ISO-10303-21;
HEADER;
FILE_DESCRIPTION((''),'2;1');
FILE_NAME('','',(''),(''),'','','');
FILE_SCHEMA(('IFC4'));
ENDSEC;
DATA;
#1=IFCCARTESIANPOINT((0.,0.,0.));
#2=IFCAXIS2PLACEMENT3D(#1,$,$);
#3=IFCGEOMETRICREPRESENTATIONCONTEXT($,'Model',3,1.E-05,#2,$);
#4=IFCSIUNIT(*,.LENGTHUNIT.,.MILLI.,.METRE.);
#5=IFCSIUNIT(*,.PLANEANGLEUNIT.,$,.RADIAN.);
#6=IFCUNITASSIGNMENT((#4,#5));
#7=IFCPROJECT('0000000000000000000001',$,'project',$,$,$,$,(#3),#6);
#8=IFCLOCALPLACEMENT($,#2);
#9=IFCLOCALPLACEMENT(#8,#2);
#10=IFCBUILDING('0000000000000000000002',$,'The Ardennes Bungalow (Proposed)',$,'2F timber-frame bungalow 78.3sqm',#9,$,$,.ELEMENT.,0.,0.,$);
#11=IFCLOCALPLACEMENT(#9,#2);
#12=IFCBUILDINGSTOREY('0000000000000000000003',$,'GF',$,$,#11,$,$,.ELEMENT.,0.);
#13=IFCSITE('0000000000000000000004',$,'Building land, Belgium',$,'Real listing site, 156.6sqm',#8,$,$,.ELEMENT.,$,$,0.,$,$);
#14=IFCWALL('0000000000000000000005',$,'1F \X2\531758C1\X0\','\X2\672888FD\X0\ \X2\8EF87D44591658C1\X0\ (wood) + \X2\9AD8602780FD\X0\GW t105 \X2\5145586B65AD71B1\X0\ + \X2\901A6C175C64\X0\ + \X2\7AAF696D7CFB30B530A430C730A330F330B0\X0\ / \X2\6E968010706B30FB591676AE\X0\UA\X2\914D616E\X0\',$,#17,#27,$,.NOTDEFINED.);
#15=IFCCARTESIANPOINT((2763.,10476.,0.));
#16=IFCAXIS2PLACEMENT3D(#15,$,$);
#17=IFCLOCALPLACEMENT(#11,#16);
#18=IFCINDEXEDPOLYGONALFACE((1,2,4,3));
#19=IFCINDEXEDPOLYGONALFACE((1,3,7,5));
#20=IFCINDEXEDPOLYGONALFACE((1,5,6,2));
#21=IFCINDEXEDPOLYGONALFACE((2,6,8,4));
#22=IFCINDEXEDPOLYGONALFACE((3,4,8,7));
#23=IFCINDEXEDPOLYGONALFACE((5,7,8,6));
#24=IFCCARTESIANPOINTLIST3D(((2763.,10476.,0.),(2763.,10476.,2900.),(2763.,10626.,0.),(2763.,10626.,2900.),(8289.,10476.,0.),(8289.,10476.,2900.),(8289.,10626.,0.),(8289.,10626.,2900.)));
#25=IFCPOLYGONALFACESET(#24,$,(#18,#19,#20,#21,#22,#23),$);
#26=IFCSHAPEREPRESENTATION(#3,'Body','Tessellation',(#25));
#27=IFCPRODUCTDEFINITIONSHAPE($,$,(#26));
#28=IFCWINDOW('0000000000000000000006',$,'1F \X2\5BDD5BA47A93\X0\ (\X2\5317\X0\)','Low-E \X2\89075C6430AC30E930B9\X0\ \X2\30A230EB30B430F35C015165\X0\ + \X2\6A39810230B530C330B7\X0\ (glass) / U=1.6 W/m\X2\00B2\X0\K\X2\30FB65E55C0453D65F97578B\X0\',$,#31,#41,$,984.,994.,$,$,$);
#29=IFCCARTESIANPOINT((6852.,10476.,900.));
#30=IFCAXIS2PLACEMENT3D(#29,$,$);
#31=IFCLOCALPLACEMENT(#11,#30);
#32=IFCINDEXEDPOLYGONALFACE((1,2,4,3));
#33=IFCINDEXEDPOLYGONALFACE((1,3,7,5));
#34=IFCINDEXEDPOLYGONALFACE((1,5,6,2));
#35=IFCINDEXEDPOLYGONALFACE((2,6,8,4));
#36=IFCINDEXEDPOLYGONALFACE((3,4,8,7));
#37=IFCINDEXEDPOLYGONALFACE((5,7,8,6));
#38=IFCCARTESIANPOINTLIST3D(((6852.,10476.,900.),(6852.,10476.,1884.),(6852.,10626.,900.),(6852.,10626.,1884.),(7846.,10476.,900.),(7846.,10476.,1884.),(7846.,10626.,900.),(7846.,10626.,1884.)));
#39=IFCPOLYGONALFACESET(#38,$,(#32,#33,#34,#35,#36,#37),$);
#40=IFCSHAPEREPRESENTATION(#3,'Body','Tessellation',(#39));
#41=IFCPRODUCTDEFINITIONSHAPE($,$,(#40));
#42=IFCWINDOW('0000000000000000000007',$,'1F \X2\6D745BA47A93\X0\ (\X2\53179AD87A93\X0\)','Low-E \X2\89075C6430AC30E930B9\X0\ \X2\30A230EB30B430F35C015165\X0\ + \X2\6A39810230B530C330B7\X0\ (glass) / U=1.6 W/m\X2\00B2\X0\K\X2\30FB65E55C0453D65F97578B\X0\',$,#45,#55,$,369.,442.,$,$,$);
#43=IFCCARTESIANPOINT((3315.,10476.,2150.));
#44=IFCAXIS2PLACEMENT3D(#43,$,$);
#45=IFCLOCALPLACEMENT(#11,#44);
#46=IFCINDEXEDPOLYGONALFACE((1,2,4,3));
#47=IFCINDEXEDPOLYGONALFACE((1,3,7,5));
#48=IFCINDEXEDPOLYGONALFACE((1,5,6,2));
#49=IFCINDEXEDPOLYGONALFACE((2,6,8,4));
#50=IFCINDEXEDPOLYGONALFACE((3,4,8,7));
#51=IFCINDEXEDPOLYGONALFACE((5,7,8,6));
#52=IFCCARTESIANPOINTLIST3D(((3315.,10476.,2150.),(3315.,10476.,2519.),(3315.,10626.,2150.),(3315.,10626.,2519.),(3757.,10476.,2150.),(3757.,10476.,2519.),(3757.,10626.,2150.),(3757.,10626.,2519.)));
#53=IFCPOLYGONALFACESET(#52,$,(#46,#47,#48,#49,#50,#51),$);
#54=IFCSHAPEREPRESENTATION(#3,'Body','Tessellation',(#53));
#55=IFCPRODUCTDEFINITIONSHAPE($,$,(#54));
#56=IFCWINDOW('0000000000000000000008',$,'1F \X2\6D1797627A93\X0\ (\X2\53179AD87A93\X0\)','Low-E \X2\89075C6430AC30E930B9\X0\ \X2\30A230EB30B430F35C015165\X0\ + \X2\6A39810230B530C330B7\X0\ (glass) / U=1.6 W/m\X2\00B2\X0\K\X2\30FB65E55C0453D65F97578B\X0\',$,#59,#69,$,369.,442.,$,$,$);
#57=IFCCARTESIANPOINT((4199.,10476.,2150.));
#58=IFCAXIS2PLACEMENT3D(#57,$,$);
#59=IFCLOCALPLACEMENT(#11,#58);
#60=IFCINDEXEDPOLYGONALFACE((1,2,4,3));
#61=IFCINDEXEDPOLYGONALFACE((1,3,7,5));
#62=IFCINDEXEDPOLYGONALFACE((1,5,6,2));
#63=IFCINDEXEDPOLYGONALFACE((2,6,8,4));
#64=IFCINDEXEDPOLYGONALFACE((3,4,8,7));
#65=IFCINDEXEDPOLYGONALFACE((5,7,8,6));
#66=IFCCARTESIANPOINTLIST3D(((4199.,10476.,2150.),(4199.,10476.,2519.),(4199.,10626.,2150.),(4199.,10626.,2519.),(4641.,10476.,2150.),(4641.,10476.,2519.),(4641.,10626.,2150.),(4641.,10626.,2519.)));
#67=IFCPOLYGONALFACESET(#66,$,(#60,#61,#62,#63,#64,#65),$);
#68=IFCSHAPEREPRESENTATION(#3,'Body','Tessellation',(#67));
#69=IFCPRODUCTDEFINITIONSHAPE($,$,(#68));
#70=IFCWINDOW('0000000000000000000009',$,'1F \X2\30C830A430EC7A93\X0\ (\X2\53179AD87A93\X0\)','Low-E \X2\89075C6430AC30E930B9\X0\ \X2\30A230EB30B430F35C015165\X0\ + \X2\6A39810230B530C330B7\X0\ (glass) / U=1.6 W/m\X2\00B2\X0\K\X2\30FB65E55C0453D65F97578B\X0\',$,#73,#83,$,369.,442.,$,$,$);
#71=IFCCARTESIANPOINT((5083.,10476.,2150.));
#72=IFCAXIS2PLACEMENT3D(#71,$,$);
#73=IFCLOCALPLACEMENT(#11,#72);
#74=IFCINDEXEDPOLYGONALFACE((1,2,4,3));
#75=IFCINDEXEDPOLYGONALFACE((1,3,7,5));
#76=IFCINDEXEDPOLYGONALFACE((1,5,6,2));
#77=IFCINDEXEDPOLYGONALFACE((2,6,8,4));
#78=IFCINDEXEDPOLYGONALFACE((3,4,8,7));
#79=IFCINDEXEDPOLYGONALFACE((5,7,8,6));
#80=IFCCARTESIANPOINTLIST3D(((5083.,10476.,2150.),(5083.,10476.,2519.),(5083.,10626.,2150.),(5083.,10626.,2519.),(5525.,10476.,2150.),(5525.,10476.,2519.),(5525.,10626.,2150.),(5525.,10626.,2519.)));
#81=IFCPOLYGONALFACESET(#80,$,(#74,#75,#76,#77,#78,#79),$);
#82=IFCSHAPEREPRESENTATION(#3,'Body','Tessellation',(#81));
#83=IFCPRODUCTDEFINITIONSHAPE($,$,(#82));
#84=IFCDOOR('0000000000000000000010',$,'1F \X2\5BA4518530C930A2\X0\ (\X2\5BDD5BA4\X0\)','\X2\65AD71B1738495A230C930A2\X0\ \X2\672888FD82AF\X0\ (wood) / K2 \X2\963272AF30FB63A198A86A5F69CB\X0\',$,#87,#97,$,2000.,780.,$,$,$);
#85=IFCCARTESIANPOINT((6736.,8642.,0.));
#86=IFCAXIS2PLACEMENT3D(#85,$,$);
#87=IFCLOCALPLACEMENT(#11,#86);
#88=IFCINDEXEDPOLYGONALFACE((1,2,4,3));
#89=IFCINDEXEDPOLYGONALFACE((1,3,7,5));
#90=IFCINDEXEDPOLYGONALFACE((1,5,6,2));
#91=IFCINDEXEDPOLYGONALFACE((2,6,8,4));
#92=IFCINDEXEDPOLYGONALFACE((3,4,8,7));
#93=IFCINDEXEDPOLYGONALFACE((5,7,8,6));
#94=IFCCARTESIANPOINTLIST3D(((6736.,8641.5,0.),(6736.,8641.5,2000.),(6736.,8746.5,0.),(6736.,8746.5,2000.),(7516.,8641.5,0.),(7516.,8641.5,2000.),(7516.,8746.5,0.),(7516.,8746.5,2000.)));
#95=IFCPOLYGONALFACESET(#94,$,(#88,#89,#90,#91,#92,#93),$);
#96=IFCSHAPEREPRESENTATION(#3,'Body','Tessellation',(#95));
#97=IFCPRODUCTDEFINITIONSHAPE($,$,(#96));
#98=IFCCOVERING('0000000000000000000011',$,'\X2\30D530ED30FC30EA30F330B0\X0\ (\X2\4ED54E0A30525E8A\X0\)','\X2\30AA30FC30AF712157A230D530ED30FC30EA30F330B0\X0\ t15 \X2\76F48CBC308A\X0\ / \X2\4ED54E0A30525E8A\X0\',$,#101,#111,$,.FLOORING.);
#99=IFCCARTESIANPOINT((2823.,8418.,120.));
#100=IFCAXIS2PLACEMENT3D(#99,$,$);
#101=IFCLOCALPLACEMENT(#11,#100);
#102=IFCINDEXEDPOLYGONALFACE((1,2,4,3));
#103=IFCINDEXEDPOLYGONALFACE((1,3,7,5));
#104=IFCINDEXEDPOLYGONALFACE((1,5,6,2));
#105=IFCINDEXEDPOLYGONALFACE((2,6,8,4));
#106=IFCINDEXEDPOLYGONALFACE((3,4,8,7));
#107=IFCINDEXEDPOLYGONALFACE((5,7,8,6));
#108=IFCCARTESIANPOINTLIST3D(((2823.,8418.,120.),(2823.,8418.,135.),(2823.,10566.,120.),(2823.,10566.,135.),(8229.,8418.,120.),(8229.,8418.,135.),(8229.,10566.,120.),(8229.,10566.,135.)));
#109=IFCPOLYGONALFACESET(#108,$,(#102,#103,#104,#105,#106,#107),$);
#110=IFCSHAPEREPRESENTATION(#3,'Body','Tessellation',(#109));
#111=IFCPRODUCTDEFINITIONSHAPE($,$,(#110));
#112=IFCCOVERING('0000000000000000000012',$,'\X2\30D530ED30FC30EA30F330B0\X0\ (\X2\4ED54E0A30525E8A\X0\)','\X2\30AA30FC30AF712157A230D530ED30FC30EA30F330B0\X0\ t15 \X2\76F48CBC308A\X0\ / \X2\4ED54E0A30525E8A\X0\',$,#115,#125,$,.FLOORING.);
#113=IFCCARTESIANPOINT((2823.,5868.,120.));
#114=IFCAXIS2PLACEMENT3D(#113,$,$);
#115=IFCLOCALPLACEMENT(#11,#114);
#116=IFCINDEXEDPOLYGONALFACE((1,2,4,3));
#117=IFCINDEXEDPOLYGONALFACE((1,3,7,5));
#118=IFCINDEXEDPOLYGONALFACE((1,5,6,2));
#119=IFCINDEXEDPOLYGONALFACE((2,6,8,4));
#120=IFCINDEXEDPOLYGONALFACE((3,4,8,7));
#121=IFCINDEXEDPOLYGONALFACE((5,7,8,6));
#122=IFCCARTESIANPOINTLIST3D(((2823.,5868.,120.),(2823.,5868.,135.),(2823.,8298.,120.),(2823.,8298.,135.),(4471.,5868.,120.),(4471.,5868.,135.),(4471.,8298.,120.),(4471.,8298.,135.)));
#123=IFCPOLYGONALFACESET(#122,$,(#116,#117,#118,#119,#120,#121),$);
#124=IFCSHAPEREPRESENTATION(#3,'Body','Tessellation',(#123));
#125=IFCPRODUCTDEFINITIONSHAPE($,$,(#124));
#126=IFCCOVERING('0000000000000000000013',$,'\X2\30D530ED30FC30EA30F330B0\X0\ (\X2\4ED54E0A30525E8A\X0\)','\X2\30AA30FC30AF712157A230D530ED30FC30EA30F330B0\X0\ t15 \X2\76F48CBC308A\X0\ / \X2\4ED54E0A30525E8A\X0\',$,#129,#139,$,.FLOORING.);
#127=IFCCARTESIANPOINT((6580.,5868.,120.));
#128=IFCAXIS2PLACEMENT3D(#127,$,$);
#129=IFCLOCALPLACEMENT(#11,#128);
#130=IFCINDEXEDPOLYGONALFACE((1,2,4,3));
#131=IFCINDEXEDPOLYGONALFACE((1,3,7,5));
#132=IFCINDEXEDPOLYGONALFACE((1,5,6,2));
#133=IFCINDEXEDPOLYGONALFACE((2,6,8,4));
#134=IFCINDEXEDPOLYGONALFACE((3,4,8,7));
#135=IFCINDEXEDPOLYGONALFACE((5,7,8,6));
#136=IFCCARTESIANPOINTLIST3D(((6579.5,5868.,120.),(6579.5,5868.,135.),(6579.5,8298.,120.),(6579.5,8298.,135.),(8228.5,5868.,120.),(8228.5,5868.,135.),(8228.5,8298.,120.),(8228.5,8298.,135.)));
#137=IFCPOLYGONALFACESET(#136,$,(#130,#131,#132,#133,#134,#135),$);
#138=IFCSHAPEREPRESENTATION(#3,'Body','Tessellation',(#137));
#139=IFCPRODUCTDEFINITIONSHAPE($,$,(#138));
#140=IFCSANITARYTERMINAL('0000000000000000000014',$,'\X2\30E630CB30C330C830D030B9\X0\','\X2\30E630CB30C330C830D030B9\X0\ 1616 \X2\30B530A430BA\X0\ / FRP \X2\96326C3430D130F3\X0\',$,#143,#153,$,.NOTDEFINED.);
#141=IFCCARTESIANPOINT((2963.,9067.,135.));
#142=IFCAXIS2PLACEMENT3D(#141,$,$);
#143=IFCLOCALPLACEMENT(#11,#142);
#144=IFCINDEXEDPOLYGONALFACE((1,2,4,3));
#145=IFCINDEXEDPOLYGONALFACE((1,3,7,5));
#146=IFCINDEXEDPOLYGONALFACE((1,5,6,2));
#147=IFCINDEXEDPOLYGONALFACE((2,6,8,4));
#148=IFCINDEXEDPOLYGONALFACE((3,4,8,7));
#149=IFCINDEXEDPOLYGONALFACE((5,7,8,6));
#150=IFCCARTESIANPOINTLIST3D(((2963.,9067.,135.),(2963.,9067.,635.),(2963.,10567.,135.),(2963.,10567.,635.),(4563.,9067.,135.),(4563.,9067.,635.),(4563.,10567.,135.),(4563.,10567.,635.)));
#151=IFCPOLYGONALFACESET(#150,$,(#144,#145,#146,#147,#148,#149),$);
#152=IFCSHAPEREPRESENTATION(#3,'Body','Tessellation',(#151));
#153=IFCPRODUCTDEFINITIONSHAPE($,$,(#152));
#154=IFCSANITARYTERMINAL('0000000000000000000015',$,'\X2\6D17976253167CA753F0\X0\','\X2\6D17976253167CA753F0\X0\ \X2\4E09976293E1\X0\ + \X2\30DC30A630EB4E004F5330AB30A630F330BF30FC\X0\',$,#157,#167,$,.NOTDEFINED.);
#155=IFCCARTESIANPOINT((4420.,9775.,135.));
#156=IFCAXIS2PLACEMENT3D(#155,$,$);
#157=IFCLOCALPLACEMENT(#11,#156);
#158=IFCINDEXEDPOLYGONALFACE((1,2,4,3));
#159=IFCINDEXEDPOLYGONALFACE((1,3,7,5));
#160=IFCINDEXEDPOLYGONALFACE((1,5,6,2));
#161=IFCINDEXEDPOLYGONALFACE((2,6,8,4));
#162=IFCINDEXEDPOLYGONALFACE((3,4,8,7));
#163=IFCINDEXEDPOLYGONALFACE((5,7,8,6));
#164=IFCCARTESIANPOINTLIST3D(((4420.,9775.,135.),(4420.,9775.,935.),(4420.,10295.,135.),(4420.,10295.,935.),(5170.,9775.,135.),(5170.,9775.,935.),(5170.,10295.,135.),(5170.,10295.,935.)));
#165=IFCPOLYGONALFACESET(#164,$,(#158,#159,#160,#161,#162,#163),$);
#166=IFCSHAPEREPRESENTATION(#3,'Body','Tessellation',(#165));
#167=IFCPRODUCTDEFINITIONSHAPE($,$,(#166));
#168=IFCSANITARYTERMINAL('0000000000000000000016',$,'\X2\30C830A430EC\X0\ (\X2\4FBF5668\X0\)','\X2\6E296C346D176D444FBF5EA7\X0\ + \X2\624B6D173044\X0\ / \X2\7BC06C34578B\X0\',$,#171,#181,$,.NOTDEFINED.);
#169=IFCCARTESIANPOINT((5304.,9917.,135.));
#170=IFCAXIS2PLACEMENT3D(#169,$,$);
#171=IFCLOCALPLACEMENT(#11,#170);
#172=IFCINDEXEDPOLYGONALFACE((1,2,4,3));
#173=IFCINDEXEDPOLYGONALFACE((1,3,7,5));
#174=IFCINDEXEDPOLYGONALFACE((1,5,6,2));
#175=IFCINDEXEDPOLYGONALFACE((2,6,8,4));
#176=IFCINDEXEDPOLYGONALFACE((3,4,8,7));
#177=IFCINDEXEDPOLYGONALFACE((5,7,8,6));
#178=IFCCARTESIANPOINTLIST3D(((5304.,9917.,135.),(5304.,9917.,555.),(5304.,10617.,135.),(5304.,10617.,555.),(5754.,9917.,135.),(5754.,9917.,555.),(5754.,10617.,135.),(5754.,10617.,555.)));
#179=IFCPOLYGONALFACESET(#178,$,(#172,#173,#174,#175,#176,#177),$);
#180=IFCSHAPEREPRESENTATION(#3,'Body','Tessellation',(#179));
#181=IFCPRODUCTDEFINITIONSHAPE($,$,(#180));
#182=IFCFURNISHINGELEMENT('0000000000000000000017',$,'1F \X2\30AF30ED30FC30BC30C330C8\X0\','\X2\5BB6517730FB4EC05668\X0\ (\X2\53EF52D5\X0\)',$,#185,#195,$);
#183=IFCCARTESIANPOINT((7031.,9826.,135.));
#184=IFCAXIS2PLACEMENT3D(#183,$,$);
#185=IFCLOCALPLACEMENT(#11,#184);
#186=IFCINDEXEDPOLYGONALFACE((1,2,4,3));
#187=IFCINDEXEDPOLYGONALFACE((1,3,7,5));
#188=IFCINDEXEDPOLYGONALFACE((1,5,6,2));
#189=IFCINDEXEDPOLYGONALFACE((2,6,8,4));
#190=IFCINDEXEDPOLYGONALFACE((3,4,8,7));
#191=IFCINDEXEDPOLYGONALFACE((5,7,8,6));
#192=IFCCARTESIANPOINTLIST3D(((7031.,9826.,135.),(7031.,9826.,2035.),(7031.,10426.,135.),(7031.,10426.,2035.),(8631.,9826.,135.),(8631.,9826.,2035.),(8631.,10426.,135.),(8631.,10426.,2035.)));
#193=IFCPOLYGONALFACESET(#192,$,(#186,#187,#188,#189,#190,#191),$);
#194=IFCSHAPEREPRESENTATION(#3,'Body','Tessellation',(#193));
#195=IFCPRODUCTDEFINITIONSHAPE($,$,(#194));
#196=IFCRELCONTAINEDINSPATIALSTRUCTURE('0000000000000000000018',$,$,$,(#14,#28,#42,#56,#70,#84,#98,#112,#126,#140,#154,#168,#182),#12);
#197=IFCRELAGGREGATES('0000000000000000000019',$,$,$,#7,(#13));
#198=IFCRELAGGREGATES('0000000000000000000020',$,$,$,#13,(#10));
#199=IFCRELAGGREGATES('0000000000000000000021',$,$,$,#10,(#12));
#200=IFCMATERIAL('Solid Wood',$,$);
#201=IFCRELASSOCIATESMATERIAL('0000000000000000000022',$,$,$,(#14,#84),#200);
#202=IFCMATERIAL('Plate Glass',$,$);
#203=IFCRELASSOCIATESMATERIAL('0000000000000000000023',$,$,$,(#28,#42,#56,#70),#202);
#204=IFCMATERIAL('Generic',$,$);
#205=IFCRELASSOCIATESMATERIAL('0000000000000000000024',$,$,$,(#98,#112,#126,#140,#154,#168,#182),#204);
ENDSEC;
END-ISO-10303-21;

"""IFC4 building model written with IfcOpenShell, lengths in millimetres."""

from ifc_helpers import new_model, si_unit, frame, frame_2d, origin, place, context, project, spatial, rectangle, extrude, material, element, fill, save


model = new_model("IFC4")

# Units and contexts
model_context = context("Model", 3, precision=1e-05, world=origin())
ifc_project = project(units=[si_unit("LENGTHUNIT", "METRE", prefix="MILLI"), si_unit("PLANEANGLEUNIT", "RADIAN")], contexts=[model_context])

# Site, building, storey
site_placement = place(None, origin())
site = spatial("IfcSite", under=ifc_project, at=site_placement, Name="Building land, Belgium", ObjectType="Real listing site, 156.6sqm", CompositionType="ELEMENT", RefElevation=0.0)
building_placement = place(site_placement, origin())
building = spatial("IfcBuilding", under=site, at=building_placement, Name="The Ardennes Bungalow (Proposed)", ObjectType="2F timber-frame bungalow 78.3sqm", CompositionType="ELEMENT", ElevationOfRefHeight=0.0, ElevationOfTerrain=0.0)
storey_placement = place(building_placement, origin())
storey = spatial("IfcBuildingStorey", under=building, at=storey_placement, Name="GF", CompositionType="ELEMENT", Elevation=0.0)

# Shared definitions
ifc_material_1 = material(Name="Solid Wood")

# Wall, openings, windows
wall_1_placement = place(storey_placement, frame((2763.0, 10476.0, 0.0)))
wall_1 = element("IfcWall", 1, at=wall_1_placement, inside=storey, material=ifc_material_1, Name="1F 北壁", Description="木製 軸組外壁 (wood) + 高性能GW t105 充填断熱 + 通気層 + 窯業系サイディング / 準耐火・外皮UA配慮", PredefinedType="NOTDEFINED", context=model_context, shape_type="SweptSolid", body=[
    extrude(rectangle(XDim=5526.0, YDim=150.0, at=frame_2d((2763.0, 75.0))), frame((2763.0, 10476.0, 0.0)), (0.0, 0.0, 1.0), 2900.0),
])
opening_1_placement = place(storey_placement, frame((6852.0, 10476.0, 900.0)))
opening_1 = element("IfcOpeningElement", 2, at=opening_1_placement, cuts=wall_1, PredefinedType="NOTDEFINED", context=model_context, shape_type="SweptSolid", body=[
    extrude(rectangle(XDim=994.0, YDim=150.0, at=frame_2d((497.0, 75.0))), frame((6852.0, 10476.0, 900.0)), (0.0, 0.0, 1.0), 984.0),
])
opening_2_placement = place(storey_placement, frame((3315.0, 10476.0, 2150.0)))
opening_2 = element("IfcOpeningElement", 3, at=opening_2_placement, cuts=wall_1, PredefinedType="NOTDEFINED", context=model_context, shape_type="SweptSolid", body=[
    extrude(rectangle(XDim=442.0, YDim=150.0, at=frame_2d((221.0, 75.0))), frame((3315.0, 10476.0, 2150.0)), (0.0, 0.0, 1.0), 369.0),
])
opening_3_placement = place(storey_placement, frame((4199.0, 10476.0, 2150.0)))
opening_3 = element("IfcOpeningElement", 4, at=opening_3_placement, cuts=wall_1, PredefinedType="NOTDEFINED", context=model_context, shape_type="SweptSolid", body=[
    extrude(rectangle(XDim=442.0, YDim=150.0, at=frame_2d((221.0, 75.0))), frame((4199.0, 10476.0, 2150.0)), (0.0, 0.0, 1.0), 369.0),
])
opening_4_placement = place(storey_placement, frame((5083.0, 10476.0, 2150.0)))
opening_4 = element("IfcOpeningElement", 5, at=opening_4_placement, cuts=wall_1, PredefinedType="NOTDEFINED", context=model_context, shape_type="SweptSolid", body=[
    extrude(rectangle(XDim=442.0, YDim=150.0, at=frame_2d((221.0, 75.0))), frame((5083.0, 10476.0, 2150.0)), (0.0, 0.0, 1.0), 369.0),
])
ifc_material_2 = material(Name="Plate Glass")
window_1_placement = place(storey_placement, frame((6852.0, 10476.0, 900.0)))
window_1 = element("IfcWindow", 6, at=window_1_placement, inside=storey, material=ifc_material_2, Name="1F 寝室窓 (北)", Description="Low-E 複層ガラス アルゴン封入 + 樹脂サッシ (glass) / U=1.6 W/m²K・日射取得型", OverallHeight=984.0, OverallWidth=994.0, context=model_context, shape_type="SweptSolid", body=[
    extrude(rectangle(XDim=994.0, YDim=150.0, at=frame_2d((497.0, 75.0))), frame((6852.0, 10476.0, 900.0)), (0.0, 0.0, 1.0), 984.0),
])
fill(opening_1, window_1)
window_2_placement = place(storey_placement, frame((3315.0, 10476.0, 2150.0)))
window_2 = element("IfcWindow", 7, at=window_2_placement, inside=storey, material=ifc_material_2, Name="1F 浴室窓 (北高窓)", Description="Low-E 複層ガラス アルゴン封入 + 樹脂サッシ (glass) / U=1.6 W/m²K・日射取得型", OverallHeight=369.0, OverallWidth=442.0, context=model_context, shape_type="SweptSolid", body=[
    extrude(rectangle(XDim=442.0, YDim=150.0, at=frame_2d((221.0, 75.0))), frame((3315.0, 10476.0, 2150.0)), (0.0, 0.0, 1.0), 369.0),
])
fill(opening_2, window_2)
window_3_placement = place(storey_placement, frame((4199.0, 10476.0, 2150.0)))
window_3 = element("IfcWindow", 8, at=window_3_placement, inside=storey, material=ifc_material_2, Name="1F 洗面窓 (北高窓)", Description="Low-E 複層ガラス アルゴン封入 + 樹脂サッシ (glass) / U=1.6 W/m²K・日射取得型", OverallHeight=369.0, OverallWidth=442.0, context=model_context, shape_type="SweptSolid", body=[
    extrude(rectangle(XDim=442.0, YDim=150.0, at=frame_2d((221.0, 75.0))), frame((4199.0, 10476.0, 2150.0)), (0.0, 0.0, 1.0), 369.0),
])
fill(opening_3, window_3)
window_4_placement = place(storey_placement, frame((5083.0, 10476.0, 2150.0)))
window_4 = element("IfcWindow", 9, at=window_4_placement, inside=storey, material=ifc_material_2, Name="1F トイレ窓 (北高窓)", Description="Low-E 複層ガラス アルゴン封入 + 樹脂サッシ (glass) / U=1.6 W/m²K・日射取得型", OverallHeight=369.0, OverallWidth=442.0, context=model_context, shape_type="SweptSolid", body=[
    extrude(rectangle(XDim=442.0, YDim=150.0, at=frame_2d((221.0, 75.0))), frame((5083.0, 10476.0, 2150.0)), (0.0, 0.0, 1.0), 369.0),
])
fill(opening_4, window_4)

# Door
door_1_placement = place(storey_placement, frame((6736.0, 8642.0, 0.0)))
element("IfcDoor", 10, at=door_1_placement, inside=storey, material=ifc_material_1, Name="1F 室内ドア (寝室)", Description="断熱玄関ドア 木製芯 (wood) / K2 防犯・採風機構", OverallHeight=2000.0, OverallWidth=780.0, context=model_context, shape_type="SweptSolid", body=[
    extrude(rectangle(XDim=780.0, YDim=105.0, at=frame_2d((390.0, 52.0))), frame((6736.0, 8642.0, 0.0)), (0.0, 0.0, 1.0), 2000.0),
])

# Coverings
ifc_material_3 = material(Name="Generic")
covering_1_placement = place(storey_placement, frame((2823.0, 8418.0, 120.0)))
element("IfcCovering", 11, at=covering_1_placement, inside=storey, material=ifc_material_3, Name="フローリング (仕上げ床)", Description="オーク無垢フローリング t15 直貼り / 仕上げ床", PredefinedType="FLOORING", context=model_context, shape_type="SweptSolid", body=[
    extrude(rectangle(XDim=5406.0, YDim=2148.0, at=frame_2d((2703.0, 1074.0))), frame((2823.0, 8418.0, 120.0)), (0.0, 0.0, 1.0), 15.0),
])
covering_2_placement = place(storey_placement, frame((2823.0, 5868.0, 120.0)))
element("IfcCovering", 12, at=covering_2_placement, inside=storey, material=ifc_material_3, Name="フローリング (仕上げ床)", Description="オーク無垢フローリング t15 直貼り / 仕上げ床", PredefinedType="FLOORING", context=model_context, shape_type="SweptSolid", body=[
    extrude(rectangle(XDim=1648.0, YDim=2430.0, at=frame_2d((824.0, 1215.0))), frame((2823.0, 5868.0, 120.0)), (0.0, 0.0, 1.0), 15.0),
])
covering_3_placement = place(storey_placement, frame((6580.0, 5868.0, 120.0)))
element("IfcCovering", 13, at=covering_3_placement, inside=storey, material=ifc_material_3, Name="フローリング (仕上げ床)", Description="オーク無垢フローリング t15 直貼り / 仕上げ床", PredefinedType="FLOORING", context=model_context, shape_type="SweptSolid", body=[
    extrude(rectangle(XDim=1649.0, YDim=2430.0, at=frame_2d((824.0, 1215.0))), frame((6580.0, 5868.0, 120.0)), (0.0, 0.0, 1.0), 15.0),
])

# Sanitary terminals
sanitary_terminal_1_placement = place(storey_placement, frame((2963.0, 9067.0, 135.0)))
element("IfcSanitaryTerminal", 14, at=sanitary_terminal_1_placement, inside=storey, material=ifc_material_3, Name="ユニットバス", Description="ユニットバス 1616 サイズ / FRP 防水パン", PredefinedType="NOTDEFINED", context=model_context, shape_type="SweptSolid", body=[
    extrude(rectangle(XDim=1600.0, YDim=1500.0, at=frame_2d((800.0, 750.0))), frame((2963.0, 9067.0, 135.0)), (0.0, 0.0, 1.0), 500.0),
])
sanitary_terminal_2_placement = place(storey_placement, frame((4420.0, 9775.0, 135.0)))
element("IfcSanitaryTerminal", 15, at=sanitary_terminal_2_placement, inside=storey, material=ifc_material_3, Name="洗面化粧台", Description="洗面化粧台 三面鏡 + ボウル一体カウンター", PredefinedType="NOTDEFINED", context=model_context, shape_type="SweptSolid", body=[
    extrude(rectangle(XDim=750.0, YDim=520.0, at=frame_2d((375.0, 260.0))), frame((4420.0, 9775.0, 135.0)), (0.0, 0.0, 1.0), 800.0),
])
sanitary_terminal_3_placement = place(storey_placement, frame((5304.0, 9917.0, 135.0)))
element("IfcSanitaryTerminal", 16, at=sanitary_terminal_3_placement, inside=storey, material=ifc_material_3, Name="トイレ (便器)", Description="温水洗浄便座 + 手洗い / 節水型", PredefinedType="NOTDEFINED", context=model_context, shape_type="SweptSolid", body=[
    extrude(rectangle(XDim=450.0, YDim=700.0, at=frame_2d((225.0, 350.0))), frame((5304.0, 9917.0, 135.0)), (0.0, 0.0, 1.0), 420.0),
])

# Furnishing element
furnishing_placement = place(storey_placement, frame((7031.0, 9826.0, 135.0)))
element("IfcFurnishingElement", 17, at=furnishing_placement, inside=storey, material=ifc_material_3, Name="1F クローゼット", Description="家具・什器 (可動)", context=model_context, shape_type="SweptSolid", body=[
    extrude(rectangle(XDim=1600.0, YDim=600.0, at=frame_2d((800.0, 300.0))), frame((7031.0, 9826.0, 135.0)), (0.0, 0.0, 1.0), 1900.0),
])

save(model, "model.ifc")
